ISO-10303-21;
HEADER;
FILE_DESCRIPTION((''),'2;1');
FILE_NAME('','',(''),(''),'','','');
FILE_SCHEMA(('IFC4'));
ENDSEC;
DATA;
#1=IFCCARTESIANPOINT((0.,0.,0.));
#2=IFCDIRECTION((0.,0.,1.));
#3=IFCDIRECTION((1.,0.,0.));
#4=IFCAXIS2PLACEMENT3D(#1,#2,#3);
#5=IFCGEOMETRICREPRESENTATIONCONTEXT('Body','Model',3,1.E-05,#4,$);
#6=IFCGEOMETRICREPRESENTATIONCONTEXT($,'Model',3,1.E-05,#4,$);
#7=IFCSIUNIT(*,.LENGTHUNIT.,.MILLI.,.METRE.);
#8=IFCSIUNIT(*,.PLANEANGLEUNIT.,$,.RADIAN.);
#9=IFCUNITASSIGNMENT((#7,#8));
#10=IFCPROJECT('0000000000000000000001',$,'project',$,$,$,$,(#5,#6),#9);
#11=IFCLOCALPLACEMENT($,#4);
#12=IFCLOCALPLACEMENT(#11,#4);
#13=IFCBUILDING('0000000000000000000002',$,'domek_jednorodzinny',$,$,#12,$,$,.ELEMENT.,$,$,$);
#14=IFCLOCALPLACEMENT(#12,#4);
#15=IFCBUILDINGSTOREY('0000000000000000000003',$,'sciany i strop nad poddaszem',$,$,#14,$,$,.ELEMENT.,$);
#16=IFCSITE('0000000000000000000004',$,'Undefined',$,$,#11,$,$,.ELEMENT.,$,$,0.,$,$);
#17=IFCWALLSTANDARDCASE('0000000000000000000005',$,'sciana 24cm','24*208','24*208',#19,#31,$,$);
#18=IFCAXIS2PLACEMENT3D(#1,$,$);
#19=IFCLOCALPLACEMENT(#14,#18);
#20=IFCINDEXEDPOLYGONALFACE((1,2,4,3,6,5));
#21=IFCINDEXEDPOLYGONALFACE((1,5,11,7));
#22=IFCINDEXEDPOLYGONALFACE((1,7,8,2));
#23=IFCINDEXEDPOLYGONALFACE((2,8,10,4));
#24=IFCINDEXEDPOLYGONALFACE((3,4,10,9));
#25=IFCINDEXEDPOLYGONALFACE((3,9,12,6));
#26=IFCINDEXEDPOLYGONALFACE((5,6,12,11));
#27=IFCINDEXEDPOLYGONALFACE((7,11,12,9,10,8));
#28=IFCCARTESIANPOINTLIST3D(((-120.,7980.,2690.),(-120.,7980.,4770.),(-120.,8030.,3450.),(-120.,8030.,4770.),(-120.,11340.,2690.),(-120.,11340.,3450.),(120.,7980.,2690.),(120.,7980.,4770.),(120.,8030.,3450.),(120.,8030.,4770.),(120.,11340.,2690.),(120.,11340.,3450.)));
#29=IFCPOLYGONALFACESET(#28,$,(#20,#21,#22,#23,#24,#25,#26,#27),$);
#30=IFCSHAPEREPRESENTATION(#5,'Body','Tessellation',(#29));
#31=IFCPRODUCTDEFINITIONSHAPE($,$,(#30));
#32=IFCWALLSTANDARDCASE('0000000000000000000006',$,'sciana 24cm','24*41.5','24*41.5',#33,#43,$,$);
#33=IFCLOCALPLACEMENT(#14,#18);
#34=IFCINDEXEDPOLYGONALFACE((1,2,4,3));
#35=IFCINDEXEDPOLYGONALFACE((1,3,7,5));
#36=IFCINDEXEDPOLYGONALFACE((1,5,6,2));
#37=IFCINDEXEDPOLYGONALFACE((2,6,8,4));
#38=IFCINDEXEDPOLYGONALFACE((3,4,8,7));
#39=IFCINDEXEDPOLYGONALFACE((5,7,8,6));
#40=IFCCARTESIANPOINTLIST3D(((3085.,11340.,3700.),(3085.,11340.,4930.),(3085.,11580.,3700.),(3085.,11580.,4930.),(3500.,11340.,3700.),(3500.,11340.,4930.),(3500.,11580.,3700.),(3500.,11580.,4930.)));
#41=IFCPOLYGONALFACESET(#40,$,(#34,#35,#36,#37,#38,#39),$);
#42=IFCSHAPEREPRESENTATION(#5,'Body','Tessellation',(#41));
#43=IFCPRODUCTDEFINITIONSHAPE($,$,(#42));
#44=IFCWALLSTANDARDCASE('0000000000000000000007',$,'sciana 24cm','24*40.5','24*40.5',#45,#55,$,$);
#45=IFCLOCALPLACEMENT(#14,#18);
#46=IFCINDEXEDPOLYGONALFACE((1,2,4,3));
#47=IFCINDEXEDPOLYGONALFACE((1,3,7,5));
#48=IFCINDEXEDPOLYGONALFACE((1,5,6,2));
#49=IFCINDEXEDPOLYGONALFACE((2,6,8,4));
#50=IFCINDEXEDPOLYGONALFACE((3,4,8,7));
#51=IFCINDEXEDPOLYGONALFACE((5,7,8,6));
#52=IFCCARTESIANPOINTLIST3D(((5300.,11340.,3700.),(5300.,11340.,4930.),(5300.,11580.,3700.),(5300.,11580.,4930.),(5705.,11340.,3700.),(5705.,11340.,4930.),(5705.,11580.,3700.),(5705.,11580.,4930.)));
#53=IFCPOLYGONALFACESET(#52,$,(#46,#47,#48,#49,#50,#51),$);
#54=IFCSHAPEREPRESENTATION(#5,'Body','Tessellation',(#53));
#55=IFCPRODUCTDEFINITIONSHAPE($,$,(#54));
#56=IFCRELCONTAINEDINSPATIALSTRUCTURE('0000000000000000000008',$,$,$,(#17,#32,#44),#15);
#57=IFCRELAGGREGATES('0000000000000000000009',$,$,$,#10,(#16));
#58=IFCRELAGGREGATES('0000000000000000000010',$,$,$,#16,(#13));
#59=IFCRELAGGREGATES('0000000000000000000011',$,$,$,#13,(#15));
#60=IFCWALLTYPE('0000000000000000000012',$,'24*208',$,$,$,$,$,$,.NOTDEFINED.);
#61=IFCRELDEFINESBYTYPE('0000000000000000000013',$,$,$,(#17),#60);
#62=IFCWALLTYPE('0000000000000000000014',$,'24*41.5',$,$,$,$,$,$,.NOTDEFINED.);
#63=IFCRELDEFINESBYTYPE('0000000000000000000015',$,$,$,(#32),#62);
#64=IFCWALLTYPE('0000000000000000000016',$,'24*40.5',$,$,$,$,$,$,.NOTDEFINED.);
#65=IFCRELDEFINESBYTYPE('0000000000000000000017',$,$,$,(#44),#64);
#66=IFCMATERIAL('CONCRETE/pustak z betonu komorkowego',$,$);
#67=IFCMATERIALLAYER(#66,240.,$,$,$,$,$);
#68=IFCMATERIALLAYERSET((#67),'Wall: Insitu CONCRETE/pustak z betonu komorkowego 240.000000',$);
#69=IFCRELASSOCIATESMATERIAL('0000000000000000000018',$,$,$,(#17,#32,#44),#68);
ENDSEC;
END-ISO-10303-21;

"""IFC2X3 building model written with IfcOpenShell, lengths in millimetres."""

from ifc_helpers import new_model, si_unit, frame, frame_2d, origin_with_axes, place, context, project, spatial, polyline, rectangle, outline, extrude, material, layer, layer_set, layer_usage, type_object, element, save


model = new_model("IFC2X3")

# Units and contexts
model_context_1 = context("Model", 3, precision=1e-05, world=origin_with_axes(), identifier="Body")
model_context_2 = context("Model", 3, precision=1e-05, world=origin_with_axes())
ifc_project = project(units=[si_unit("LENGTHUNIT", "METRE", prefix="MILLI"), si_unit("PLANEANGLEUNIT", "RADIAN")], contexts=[model_context_1, model_context_2])

# Site, building, storey
site_placement = place(None, origin_with_axes())
site = spatial("IfcSite", under=ifc_project, at=site_placement, Name="Undefined", CompositionType="ELEMENT", RefElevation=0.0)
building_placement = place(site_placement, origin_with_axes())
building = spatial("IfcBuilding", under=site, at=building_placement, Name="domek_jednorodzinny", CompositionType="ELEMENT")
storey_placement = place(building_placement, origin_with_axes())
storey = spatial("IfcBuildingStorey", under=building, at=storey_placement, Name="sciany i strop nad poddaszem", CompositionType="ELEMENT")

# Shared definitions
ifc_material_1 = material(Name="CONCRETE/pustak z betonu komorkowego")

# Shared definitions
ifc_layer_1 = layer(ifc_material_1, 240.0)
ifc_layer_set_1 = layer_set([ifc_layer_1], Name="Wall: Insitu CONCRETE/pustak z betonu komorkowego 240.000000")

# Wall, opening
ifc_layer_usage_1 = layer_usage(ifc_layer_set_1, "AXIS2", "POSITIVE", -120.0)
wall_type_1 = type_object("IfcWallType", Name="24*208", PredefinedType="NOTDEFINED")
wall_1_placement = place(storey_placement, frame((0.0, 7980.0, 2690.0), z_axis=(0.0, 0.0, 1.0), x_axis=(0.0, 1.0, 0.0)))
wall_1 = element("IfcWallStandardCase", 1, at=wall_1_placement, inside=storey, type_object=wall_type_1, material=ifc_layer_usage_1, Name="sciana 24cm", Description="24*208", ObjectType="24*208", context=model_context_1, shape_type="SweptSolid", body=[
    extrude(rectangle(XDim=3360.0, YDim=240.0, at=frame_2d((0.0, 1680.0), x_axis=(0.0, -1.0))), frame((0.0, 0.0, 0.0), z_axis=(0.0, 0.0, 1.0), x_axis=(0.0, -1.0, 0.0)), (0.0, 0.0, 1.0), 2080.0),
])
opening_1_placement = place(storey_placement, frame((0.0, 7980.0, 2690.0), z_axis=(0.0, 0.0, 1.0), x_axis=(0.0, 1.0, 0.0)))
element("IfcOpeningElement", 2, at=opening_1_placement, cuts=wall_1, ObjectType="Recess", context=model_context_1, shape_type="SweptSolid", body=[
    extrude(outline(polyline([(0.0, 0.0), (1700.0, 0.0), (1700.0, 3310.0), (0.0, 3310.0), (0.0, 0.0)])), frame((50.0, -153.0, 760.0), z_axis=(0.0, 1.0, 0.0), x_axis=(0.0, 0.0, 1.0)), (0.0, 0.0, 1.0), 306.0),
])

# Walls
ifc_layer_usage_2 = layer_usage(ifc_layer_set_1, "AXIS2", "POSITIVE", -120.0)
wall_type_2 = type_object("IfcWallType", Name="24*41.5", PredefinedType="NOTDEFINED")
wall_2_placement = place(storey_placement, frame((3085.0, 11460.0, 3700.0), z_axis=(0.0, 0.0, 1.0), x_axis=(1.0, 0.0, 0.0)))
element("IfcWallStandardCase", 3, at=wall_2_placement, inside=storey, type_object=wall_type_2, material=ifc_layer_usage_2, Name="sciana 24cm", Description="24*41.5", ObjectType="24*41.5", context=model_context_1, shape_type="SweptSolid", body=[
    extrude(rectangle(XDim=415.0, YDim=240.0, at=frame_2d((0.0, 207.5), x_axis=(0.0, -1.0))), frame((0.0, 0.0, 0.0), z_axis=(0.0, 0.0, 1.0), x_axis=(0.0, -1.0, 0.0)), (0.0, 0.0, 1.0), 1230.0),
])
ifc_layer_usage_3 = layer_usage(ifc_layer_set_1, "AXIS2", "POSITIVE", -120.0)
wall_type_3 = type_object("IfcWallType", Name="24*40.5", PredefinedType="NOTDEFINED")
wall_3_placement = place(storey_placement, frame((5300.0, 11460.0, 3700.0), z_axis=(0.0, 0.0, 1.0), x_axis=(1.0, 0.0, 0.0)))
element("IfcWallStandardCase", 4, at=wall_3_placement, inside=storey, type_object=wall_type_3, material=ifc_layer_usage_3, Name="sciana 24cm", Description="24*40.5", ObjectType="24*40.5", context=model_context_1, shape_type="SweptSolid", body=[
    extrude(rectangle(XDim=405.0, YDim=240.0, at=frame_2d((0.0, 202.5), x_axis=(0.0, -1.0))), frame((0.0, 0.0, 0.0), z_axis=(0.0, 0.0, 1.0), x_axis=(0.0, -1.0, 0.0)), (0.0, 0.0, 1.0), 1230.0),
])

save(model, "model.ifc")
